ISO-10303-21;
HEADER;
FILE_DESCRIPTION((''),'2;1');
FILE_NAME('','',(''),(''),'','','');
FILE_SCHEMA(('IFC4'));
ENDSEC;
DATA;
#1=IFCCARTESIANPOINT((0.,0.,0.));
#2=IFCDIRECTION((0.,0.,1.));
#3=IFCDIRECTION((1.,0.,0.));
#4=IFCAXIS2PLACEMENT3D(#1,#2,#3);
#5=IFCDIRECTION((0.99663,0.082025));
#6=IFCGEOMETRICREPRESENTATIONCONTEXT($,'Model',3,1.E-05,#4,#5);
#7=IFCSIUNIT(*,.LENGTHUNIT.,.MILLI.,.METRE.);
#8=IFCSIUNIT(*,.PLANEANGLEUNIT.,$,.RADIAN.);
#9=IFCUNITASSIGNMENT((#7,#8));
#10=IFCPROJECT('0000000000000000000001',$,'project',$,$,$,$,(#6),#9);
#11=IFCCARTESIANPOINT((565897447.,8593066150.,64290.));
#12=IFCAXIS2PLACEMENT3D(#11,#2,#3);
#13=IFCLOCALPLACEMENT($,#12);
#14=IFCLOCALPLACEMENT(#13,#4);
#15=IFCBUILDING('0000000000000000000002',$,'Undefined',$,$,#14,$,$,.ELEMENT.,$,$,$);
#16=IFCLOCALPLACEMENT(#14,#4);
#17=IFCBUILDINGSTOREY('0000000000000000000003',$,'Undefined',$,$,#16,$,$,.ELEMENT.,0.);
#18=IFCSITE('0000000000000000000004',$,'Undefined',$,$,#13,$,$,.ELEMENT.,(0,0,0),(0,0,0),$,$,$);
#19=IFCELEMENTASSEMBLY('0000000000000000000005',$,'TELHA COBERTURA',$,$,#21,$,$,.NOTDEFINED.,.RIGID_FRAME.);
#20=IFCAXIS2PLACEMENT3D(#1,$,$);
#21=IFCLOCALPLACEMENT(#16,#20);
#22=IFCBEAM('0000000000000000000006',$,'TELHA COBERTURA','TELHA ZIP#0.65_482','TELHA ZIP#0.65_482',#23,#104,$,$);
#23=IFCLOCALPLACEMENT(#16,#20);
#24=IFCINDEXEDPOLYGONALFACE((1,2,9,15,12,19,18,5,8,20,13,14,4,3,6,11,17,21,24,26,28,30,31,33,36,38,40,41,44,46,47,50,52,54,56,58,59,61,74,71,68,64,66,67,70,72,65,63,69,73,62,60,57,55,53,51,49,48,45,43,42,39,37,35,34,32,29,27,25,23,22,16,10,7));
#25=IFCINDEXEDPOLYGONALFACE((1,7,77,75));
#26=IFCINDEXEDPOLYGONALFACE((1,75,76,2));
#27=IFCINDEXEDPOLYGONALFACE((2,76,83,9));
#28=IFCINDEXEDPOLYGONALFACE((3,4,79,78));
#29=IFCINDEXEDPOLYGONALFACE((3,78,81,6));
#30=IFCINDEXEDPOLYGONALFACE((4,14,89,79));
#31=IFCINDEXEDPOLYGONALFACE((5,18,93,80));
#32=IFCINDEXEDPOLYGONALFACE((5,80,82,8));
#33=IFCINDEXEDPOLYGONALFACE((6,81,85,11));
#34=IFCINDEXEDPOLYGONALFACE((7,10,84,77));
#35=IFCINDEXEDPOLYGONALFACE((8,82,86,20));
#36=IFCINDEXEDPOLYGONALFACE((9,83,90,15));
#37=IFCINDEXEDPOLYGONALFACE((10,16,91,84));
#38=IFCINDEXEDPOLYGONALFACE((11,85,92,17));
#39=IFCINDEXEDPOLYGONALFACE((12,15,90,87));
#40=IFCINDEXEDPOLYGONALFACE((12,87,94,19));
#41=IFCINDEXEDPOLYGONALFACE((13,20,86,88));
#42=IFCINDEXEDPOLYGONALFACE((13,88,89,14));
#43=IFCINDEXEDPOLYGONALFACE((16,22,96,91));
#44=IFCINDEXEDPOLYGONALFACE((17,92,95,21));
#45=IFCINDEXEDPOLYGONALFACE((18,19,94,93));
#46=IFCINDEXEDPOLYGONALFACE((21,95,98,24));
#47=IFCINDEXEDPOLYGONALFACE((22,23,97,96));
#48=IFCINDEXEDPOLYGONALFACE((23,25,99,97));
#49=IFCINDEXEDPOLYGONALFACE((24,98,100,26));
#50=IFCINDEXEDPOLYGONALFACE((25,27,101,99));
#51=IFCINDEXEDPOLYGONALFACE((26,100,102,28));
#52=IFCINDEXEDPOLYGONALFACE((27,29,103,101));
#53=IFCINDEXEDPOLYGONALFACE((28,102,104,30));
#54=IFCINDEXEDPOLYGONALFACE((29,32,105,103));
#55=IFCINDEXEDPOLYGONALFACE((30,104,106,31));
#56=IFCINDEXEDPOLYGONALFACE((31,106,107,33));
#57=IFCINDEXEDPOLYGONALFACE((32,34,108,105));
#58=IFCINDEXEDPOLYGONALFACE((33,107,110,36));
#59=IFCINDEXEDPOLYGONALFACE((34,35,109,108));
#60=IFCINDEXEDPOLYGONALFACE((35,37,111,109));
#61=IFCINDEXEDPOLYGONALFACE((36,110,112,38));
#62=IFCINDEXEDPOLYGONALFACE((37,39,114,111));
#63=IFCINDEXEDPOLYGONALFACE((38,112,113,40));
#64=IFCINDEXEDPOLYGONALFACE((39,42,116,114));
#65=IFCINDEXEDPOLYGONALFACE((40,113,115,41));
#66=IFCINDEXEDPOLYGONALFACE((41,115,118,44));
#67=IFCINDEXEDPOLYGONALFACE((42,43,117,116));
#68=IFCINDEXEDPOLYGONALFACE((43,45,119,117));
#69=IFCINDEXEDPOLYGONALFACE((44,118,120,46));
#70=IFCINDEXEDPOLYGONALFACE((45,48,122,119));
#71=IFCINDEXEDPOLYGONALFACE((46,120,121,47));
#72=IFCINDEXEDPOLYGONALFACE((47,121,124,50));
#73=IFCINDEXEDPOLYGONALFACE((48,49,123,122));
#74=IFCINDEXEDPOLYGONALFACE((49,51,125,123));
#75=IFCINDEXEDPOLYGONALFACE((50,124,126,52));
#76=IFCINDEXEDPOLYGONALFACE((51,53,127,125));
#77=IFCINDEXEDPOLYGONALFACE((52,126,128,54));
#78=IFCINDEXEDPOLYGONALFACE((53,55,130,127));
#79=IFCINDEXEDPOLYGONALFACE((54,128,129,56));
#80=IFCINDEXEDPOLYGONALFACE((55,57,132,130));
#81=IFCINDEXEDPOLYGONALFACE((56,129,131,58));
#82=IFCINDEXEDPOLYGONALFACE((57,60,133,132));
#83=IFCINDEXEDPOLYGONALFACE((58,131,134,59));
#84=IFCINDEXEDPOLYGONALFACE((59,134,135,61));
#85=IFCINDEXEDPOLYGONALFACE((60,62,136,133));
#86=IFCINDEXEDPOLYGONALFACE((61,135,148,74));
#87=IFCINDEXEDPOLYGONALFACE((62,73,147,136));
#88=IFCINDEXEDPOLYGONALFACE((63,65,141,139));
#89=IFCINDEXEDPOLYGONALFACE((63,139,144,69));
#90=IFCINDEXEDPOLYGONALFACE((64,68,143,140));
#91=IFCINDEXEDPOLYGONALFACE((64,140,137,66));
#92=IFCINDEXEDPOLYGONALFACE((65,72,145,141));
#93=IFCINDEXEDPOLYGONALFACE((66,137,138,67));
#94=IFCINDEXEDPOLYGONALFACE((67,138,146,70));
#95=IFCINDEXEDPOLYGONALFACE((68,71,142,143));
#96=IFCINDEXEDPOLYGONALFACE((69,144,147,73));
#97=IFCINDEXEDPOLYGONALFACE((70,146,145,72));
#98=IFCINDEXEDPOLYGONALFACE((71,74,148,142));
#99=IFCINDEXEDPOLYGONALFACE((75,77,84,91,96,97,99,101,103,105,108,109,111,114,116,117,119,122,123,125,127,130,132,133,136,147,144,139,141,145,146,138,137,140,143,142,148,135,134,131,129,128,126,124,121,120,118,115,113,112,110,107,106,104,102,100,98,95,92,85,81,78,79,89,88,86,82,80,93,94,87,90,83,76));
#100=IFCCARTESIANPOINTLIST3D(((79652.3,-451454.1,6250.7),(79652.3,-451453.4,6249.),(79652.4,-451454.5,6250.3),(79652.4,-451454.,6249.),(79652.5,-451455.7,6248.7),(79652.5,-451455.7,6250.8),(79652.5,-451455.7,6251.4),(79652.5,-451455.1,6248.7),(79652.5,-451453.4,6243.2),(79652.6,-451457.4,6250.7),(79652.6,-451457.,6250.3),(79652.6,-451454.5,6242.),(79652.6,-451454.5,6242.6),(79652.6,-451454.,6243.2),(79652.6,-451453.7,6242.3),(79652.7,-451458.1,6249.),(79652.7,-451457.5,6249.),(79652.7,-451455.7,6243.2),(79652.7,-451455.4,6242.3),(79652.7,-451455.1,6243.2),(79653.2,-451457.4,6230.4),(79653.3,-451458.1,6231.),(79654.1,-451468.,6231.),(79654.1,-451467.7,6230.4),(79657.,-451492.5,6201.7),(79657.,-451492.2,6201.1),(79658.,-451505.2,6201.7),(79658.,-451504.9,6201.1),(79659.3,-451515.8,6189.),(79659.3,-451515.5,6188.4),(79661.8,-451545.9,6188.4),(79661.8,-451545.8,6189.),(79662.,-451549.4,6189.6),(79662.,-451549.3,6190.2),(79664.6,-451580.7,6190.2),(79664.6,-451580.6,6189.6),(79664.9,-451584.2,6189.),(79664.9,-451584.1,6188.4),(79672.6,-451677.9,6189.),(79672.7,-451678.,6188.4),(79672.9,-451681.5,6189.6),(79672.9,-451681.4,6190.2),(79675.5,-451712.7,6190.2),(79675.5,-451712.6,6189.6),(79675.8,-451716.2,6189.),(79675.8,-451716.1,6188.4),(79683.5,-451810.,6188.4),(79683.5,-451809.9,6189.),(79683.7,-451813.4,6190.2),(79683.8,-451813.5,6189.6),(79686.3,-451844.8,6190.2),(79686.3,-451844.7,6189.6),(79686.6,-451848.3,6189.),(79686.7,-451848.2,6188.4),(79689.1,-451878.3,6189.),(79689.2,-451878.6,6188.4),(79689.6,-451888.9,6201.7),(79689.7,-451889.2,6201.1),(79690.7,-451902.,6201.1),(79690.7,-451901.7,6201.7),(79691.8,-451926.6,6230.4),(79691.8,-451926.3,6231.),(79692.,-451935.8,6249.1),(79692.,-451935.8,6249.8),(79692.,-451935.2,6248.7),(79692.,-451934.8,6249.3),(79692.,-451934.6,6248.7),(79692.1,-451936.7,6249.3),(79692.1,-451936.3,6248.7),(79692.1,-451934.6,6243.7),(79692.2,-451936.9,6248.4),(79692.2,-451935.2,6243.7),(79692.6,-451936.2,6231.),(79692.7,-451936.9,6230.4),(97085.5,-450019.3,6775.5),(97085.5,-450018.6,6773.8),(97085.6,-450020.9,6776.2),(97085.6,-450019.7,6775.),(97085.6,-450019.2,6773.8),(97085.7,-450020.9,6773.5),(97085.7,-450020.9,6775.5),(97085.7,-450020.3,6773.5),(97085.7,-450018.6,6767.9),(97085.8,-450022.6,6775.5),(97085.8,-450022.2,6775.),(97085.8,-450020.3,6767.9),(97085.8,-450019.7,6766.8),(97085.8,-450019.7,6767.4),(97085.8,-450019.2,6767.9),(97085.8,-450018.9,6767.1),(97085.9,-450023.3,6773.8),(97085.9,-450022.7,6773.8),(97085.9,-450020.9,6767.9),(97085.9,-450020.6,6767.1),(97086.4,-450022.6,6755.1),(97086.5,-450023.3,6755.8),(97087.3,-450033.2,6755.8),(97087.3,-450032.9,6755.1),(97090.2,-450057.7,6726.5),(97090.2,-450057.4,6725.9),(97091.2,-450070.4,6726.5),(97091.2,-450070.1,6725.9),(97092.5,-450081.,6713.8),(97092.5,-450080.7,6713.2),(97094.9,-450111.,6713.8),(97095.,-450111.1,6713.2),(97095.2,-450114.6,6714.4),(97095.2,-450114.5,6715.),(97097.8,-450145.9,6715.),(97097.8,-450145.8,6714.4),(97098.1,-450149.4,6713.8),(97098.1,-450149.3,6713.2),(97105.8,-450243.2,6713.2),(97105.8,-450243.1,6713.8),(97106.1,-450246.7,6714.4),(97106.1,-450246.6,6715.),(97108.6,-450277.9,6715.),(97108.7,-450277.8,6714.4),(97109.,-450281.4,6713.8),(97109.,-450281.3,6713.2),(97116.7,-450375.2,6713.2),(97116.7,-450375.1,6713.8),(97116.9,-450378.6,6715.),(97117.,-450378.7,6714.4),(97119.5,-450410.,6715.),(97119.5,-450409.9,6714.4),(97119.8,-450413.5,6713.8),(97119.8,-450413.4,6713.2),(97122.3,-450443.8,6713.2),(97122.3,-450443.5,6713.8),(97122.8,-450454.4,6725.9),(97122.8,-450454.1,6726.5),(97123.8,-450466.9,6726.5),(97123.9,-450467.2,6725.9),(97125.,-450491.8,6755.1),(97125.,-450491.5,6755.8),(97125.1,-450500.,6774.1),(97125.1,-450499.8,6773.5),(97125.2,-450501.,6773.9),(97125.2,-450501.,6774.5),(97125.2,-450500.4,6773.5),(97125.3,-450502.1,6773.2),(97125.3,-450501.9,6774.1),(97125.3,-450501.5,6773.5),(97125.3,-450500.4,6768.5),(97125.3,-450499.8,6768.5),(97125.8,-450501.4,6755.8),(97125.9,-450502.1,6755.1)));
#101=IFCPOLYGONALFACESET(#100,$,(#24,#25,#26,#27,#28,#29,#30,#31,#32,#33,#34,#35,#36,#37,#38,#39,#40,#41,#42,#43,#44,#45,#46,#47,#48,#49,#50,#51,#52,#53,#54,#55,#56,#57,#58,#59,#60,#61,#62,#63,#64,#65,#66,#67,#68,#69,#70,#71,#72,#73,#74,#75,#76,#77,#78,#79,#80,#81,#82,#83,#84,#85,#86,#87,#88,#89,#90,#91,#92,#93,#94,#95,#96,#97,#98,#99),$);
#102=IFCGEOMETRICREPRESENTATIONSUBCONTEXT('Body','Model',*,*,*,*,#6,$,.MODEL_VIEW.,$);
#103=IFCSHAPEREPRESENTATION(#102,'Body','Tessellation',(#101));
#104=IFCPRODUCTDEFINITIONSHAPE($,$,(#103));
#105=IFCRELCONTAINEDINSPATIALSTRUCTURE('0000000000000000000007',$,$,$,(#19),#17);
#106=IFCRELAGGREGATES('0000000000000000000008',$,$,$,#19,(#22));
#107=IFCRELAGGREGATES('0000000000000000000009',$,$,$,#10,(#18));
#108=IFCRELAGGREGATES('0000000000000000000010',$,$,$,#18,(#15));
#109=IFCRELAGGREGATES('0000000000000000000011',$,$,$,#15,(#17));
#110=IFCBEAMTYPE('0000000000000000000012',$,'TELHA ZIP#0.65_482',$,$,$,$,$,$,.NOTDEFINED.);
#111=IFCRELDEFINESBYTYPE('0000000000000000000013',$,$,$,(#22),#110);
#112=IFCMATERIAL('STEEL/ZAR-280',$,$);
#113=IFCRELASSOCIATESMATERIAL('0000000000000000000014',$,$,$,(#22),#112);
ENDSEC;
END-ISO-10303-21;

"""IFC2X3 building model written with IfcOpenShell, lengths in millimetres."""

from ifc_helpers import new_model, si_unit, direction, frame, origin_with_axes, place, context, subcontext, project, spatial, polyline, outline, extrude, material, type_object, element, aggregate, save


model = new_model("IFC2X3")

# Units and contexts
model_context = context("Model", 3, precision=1e-05, world=origin_with_axes(), true_north=direction((0.99663, 0.082025)))
body_context = subcontext(model_context, "Body", "Model", "MODEL_VIEW")
ifc_project = project(units=[si_unit("LENGTHUNIT", "METRE", prefix="MILLI"), si_unit("PLANEANGLEUNIT", "RADIAN")], contexts=[model_context])

# Site, building, storey
site_placement = place(None, frame((565897447.0, 8593066150.0, 64290.0), z_axis=(0.0, 0.0, 1.0), x_axis=(1.0, 0.0, 0.0)))
site = spatial("IfcSite", under=ifc_project, at=site_placement, Name="Undefined", CompositionType="ELEMENT", RefLatitude=(0, 0, 0), RefLongitude=(0, 0, 0))
building_placement = place(site_placement, origin_with_axes())
building = spatial("IfcBuilding", under=site, at=building_placement, Name="Undefined", CompositionType="ELEMENT")
storey_placement = place(building_placement, origin_with_axes())
storey = spatial("IfcBuildingStorey", under=building, at=storey_placement, Name="Undefined", CompositionType="ELEMENT", Elevation=0.0)

# Element assembly, beam
ifc_material_1 = material(Name="STEEL/ZAR-280")
beam_type_1 = type_object("IfcBeamType", Name="TELHA ZIP#0.65_482", PredefinedType="NOTDEFINED")
assembly_1_placement = place(storey_placement, origin_with_axes())
assembly_1 = element("IfcElementAssembly", 1, at=assembly_1_placement, inside=storey, Name="TELHA COBERTURA", AssemblyPlace="NOTDEFINED", PredefinedType="RIGID_FRAME")
beam_1_placement = place(assembly_1_placement, frame((79673.1, -451695.1, 6219.6), z_axis=(-0.029885, -0.00246, 0.99955), x_axis=(0.996182, 0.081989, 0.029987)))
beam_1 = element("IfcBeam", 2, at=beam_1_placement, type_object=beam_type_1, material=ifc_material_1, Name="TELHA COBERTURA", Description="TELHA ZIP#0.65_482", ObjectType="TELHA ZIP#0.65_482", context=body_context, shape_type="SweptSolid", body=[
    extrude(outline(polyline([(240.5, 29.7), (241.4, 30.2), (242.4, 29.7), (242.6, 28.9), (242.6, 10.8), (232.2, 10.8), (207.6, -18.5), (194.9, -18.5), (184.2, -31.2), (153.7, -31.2), (150.2, -30.0), (118.9, -30.0), (115.4, -31.2), (21.2, -31.2), (17.7, -30.0), (-13.6, -30.0), (-17.1, -31.2), (-111.3, -31.2), (-114.8, -30.0), (-146.1, -30.0), (-149.6, -31.2), (-180.1, -31.2), (-190.8, -18.5), (-203.6, -18.5), (-228.1, 10.8), (-238.5, 10.8), (-238.5, 29.5), (-239.0, 30.7), (-240.2, 31.2), (-241.4, 30.7), (-241.9, 29.5), (-241.9, 23.6), (-241.4, 23.1), (-240.9, 23.6), (-240.9, 29.1), (-240.2, 29.1), (-240.2, 23.6), (-240.6, 22.8), (-241.4, 22.4), (-242.3, 22.8), (-242.6, 23.6), (-242.6, 29.5), (-241.9, 31.2), (-240.2, 31.9), (-238.5, 31.2), (-237.9, 29.5), (-237.9, 11.4), (-227.8, 11.4), (-203.2, -17.9), (-190.4, -17.9), (-179.8, -30.5), (-149.7, -30.5), (-146.2, -29.4), (-114.7, -29.4), (-111.2, -30.5), (-17.2, -30.5), (-13.7, -29.4), (17.8, -29.4), (21.3, -30.5), (115.3, -30.5), (118.8, -29.4), (150.3, -29.4), (153.8, -30.5), (183.9, -30.5), (194.6, -17.9), (207.4, -17.9), (231.9, 11.4), (241.9, 11.4), (241.9, 29.1), (241.4, 29.5), (240.9, 29.1), (240.9, 24.1), (240.2, 24.1), (240.2, 29.2), (240.5, 29.7)])), frame((17500.0, 0.0, 0.0), z_axis=(-1.0, 0.0, 0.0), x_axis=(0.0, -1.0, 0.0)), (0.0, 0.0, 1.0), 17500.0),
])
aggregate(assembly_1, [beam_1])

save(model, "model.ifc")
